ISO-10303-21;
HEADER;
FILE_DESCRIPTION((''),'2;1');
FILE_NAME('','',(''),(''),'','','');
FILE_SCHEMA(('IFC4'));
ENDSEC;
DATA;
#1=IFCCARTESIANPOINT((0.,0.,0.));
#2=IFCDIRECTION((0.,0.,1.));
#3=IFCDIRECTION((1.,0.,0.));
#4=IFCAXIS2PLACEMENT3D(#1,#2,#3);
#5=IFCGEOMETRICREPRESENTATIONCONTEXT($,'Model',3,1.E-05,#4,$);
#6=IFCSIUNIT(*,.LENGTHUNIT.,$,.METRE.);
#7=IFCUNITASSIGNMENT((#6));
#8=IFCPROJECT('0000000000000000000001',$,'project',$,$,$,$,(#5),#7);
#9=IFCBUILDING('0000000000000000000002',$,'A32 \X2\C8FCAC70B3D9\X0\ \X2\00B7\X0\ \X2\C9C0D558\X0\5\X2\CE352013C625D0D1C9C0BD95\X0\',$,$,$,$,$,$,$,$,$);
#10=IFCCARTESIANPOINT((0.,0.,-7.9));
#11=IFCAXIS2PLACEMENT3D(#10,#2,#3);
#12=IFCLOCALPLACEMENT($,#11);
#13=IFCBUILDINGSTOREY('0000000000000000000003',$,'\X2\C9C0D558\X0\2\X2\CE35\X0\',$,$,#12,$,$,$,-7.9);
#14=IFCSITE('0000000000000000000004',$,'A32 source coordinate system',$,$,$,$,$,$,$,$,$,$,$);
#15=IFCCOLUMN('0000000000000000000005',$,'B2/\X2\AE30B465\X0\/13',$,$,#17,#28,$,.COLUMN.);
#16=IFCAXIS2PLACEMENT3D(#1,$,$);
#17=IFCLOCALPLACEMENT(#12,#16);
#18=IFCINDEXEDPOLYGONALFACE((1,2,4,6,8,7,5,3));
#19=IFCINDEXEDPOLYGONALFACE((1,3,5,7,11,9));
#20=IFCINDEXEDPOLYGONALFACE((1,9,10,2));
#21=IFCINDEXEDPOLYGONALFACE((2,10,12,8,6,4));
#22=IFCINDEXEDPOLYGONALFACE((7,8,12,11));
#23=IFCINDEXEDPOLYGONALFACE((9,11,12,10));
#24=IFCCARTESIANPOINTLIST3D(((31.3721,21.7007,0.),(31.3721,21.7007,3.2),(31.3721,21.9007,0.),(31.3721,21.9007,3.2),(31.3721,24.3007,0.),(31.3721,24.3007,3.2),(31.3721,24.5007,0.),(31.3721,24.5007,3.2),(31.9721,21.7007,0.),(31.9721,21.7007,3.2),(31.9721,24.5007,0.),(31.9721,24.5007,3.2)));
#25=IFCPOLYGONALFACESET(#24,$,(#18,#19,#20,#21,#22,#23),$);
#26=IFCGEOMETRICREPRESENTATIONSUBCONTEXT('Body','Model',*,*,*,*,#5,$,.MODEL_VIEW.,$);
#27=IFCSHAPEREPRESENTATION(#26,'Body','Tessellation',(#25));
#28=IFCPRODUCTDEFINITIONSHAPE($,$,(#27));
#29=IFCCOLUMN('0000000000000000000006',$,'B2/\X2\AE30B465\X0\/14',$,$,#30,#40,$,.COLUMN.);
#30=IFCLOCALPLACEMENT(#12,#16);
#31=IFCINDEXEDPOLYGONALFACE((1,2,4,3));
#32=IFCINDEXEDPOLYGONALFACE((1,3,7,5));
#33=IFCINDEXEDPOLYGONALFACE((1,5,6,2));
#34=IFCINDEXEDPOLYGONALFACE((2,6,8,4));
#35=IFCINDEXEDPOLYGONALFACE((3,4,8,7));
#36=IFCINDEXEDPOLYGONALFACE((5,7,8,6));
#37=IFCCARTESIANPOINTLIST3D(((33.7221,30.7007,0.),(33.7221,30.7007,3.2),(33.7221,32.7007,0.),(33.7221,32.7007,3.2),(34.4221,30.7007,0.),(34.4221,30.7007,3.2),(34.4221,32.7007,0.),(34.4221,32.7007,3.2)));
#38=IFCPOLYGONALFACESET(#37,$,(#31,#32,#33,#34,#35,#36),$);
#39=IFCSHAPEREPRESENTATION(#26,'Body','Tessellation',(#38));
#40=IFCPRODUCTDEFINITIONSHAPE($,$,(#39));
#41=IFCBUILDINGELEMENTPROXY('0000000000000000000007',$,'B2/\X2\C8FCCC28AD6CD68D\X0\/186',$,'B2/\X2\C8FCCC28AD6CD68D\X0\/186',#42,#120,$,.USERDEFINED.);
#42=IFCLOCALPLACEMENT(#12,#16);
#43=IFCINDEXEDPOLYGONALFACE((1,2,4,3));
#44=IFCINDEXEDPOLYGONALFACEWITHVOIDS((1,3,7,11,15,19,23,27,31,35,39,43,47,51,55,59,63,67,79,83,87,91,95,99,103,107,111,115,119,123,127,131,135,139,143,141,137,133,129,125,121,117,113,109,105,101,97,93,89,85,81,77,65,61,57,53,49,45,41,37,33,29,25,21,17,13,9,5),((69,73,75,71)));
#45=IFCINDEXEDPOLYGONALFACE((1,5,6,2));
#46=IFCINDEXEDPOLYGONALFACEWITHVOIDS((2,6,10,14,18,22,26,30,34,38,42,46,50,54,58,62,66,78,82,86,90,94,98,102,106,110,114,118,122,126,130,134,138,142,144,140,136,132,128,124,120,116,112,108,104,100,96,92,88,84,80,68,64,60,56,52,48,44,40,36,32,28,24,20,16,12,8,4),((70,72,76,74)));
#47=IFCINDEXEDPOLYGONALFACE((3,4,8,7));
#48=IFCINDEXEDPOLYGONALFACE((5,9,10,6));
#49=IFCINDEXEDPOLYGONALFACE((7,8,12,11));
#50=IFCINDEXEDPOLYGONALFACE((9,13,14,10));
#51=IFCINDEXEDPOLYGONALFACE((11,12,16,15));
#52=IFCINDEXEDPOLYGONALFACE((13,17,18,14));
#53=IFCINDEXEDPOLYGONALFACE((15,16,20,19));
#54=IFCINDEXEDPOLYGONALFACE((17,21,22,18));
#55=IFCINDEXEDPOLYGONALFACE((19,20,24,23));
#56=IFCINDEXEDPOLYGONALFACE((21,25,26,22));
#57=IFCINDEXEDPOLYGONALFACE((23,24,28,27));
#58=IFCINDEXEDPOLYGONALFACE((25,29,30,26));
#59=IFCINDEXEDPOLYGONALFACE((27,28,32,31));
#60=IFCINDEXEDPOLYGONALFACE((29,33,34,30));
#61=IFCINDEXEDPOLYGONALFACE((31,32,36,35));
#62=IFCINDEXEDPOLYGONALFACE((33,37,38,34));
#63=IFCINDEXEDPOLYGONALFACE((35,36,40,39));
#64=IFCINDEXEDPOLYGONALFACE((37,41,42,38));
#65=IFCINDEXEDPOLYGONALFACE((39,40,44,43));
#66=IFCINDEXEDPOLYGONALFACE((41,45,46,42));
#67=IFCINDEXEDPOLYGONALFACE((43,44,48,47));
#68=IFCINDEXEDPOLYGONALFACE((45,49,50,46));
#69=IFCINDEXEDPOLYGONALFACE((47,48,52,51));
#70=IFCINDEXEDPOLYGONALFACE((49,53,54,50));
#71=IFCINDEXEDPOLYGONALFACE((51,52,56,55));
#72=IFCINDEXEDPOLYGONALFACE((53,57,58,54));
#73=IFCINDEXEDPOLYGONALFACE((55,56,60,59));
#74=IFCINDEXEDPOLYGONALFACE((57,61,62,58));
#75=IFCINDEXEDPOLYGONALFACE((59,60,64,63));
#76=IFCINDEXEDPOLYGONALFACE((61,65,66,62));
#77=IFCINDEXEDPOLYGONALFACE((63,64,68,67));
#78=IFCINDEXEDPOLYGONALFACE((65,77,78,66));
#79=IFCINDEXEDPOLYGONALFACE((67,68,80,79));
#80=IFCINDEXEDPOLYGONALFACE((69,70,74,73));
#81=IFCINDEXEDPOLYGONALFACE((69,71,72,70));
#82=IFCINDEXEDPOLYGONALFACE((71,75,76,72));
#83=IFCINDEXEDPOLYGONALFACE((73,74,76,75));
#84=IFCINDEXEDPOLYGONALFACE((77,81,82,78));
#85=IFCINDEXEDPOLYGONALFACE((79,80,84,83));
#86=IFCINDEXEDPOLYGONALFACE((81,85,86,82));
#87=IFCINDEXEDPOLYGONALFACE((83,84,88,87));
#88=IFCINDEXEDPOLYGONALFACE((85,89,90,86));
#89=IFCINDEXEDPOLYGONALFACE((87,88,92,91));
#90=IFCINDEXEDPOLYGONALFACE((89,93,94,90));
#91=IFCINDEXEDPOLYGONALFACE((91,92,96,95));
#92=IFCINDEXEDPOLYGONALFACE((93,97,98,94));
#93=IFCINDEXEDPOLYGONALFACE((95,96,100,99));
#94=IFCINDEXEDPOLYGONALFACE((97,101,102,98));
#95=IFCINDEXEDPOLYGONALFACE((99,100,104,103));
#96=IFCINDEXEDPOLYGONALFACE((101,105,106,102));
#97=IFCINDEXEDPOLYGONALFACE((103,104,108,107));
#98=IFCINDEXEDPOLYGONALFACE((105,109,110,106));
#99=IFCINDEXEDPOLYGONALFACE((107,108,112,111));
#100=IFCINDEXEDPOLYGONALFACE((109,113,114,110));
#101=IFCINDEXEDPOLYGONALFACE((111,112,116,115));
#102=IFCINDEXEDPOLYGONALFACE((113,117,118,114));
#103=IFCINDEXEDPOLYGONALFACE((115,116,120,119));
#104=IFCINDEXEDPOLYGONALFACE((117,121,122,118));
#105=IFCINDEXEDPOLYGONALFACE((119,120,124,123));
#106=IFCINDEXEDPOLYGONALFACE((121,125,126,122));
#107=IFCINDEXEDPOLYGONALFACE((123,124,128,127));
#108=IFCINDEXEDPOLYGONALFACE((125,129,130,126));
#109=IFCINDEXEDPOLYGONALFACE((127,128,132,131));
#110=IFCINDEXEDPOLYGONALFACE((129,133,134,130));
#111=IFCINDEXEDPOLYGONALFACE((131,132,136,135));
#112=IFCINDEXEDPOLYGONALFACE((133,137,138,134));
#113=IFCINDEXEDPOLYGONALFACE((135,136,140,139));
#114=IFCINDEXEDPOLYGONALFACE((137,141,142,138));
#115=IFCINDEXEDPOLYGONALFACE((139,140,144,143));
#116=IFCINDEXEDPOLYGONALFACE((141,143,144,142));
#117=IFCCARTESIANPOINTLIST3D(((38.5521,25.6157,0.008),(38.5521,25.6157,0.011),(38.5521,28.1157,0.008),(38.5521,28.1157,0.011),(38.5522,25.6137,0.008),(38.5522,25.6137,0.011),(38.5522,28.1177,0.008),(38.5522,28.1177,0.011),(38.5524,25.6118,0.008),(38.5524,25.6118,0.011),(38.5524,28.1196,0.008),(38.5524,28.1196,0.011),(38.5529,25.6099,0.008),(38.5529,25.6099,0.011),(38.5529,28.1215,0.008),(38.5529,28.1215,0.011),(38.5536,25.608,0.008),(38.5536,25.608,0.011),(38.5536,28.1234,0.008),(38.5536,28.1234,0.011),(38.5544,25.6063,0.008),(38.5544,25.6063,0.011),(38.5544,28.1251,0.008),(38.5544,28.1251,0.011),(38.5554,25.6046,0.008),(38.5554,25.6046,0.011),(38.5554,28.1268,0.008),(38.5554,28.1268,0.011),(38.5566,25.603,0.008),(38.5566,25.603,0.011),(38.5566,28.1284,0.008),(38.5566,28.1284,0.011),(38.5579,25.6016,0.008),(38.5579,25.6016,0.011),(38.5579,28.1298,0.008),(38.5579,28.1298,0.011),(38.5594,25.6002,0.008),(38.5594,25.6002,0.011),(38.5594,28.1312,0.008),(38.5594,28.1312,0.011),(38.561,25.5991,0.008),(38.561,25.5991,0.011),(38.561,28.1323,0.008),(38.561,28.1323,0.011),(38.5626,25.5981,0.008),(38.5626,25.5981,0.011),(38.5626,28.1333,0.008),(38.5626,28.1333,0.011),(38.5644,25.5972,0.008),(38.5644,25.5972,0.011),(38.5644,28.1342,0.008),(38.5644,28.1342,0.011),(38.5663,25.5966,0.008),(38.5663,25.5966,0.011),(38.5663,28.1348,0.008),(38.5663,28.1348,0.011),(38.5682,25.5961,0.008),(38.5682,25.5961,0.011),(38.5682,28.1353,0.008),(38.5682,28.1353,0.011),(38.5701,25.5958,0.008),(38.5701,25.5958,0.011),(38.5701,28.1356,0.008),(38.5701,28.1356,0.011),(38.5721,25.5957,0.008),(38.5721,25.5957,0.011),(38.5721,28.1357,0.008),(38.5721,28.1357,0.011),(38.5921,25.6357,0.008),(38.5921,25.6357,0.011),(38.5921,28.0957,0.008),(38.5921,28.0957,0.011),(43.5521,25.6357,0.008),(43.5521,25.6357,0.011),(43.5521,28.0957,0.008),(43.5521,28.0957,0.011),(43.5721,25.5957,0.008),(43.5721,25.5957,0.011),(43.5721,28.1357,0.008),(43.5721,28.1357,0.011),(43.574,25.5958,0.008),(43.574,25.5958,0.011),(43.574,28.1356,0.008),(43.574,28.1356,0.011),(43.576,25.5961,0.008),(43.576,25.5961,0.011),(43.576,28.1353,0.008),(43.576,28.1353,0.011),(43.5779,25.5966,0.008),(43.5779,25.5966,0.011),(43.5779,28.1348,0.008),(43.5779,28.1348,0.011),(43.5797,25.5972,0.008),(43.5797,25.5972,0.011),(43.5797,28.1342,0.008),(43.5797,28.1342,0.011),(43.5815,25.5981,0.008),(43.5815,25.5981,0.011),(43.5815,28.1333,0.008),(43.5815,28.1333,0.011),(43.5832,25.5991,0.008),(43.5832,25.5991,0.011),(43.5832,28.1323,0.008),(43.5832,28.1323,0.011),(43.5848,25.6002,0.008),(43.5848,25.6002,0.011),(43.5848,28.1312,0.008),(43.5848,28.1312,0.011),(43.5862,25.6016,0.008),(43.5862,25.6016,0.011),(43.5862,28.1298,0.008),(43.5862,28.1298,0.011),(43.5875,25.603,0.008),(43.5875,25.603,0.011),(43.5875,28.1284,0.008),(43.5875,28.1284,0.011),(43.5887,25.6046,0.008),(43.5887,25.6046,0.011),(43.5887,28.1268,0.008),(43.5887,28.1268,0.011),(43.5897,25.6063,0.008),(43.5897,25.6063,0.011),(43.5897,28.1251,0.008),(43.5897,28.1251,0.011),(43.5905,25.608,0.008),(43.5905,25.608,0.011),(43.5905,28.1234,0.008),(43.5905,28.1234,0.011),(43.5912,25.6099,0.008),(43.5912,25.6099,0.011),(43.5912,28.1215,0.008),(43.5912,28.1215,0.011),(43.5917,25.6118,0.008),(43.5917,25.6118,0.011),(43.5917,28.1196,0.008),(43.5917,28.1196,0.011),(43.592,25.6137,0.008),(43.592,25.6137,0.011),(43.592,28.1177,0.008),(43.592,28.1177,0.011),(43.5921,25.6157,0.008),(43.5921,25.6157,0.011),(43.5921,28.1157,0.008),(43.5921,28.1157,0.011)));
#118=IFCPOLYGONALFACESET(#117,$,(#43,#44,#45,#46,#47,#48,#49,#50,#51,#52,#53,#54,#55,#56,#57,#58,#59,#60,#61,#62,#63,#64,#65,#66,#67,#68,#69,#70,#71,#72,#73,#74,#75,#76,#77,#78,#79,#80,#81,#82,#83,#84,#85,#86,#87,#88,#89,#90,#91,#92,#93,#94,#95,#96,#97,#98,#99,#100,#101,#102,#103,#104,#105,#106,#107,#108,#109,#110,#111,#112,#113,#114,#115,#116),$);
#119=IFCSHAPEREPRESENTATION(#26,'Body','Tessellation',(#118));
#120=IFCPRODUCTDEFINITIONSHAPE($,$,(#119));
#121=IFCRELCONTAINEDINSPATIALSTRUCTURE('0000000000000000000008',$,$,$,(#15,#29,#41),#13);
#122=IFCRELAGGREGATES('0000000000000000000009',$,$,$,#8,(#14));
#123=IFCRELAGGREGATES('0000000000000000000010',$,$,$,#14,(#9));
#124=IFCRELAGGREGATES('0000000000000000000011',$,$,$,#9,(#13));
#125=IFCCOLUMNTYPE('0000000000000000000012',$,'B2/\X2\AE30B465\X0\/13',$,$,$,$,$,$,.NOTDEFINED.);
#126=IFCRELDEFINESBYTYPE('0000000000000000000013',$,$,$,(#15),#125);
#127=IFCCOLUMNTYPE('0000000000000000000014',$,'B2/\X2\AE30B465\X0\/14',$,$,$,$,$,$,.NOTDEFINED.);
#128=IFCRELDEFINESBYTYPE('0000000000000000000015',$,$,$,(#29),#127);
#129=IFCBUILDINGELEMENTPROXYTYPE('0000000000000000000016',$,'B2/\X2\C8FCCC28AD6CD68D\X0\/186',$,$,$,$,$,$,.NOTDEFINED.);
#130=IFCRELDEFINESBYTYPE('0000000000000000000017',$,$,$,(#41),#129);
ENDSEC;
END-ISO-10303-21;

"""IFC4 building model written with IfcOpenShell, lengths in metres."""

from ifc_helpers import new_model, si_unit, frame, origin, origin_with_axes, place, context, subcontext, project, spatial, polyline, outline, extrude, source, transform, mapped, type_object, type_shapes, element, save


model = new_model("IFC4")

# Units and contexts
model_context = context("Model", 3, precision=1e-05, world=origin_with_axes())
body_context = subcontext(model_context, "Body", "Model", "MODEL_VIEW")
ifc_project = project(units=[si_unit("LENGTHUNIT", "METRE")], contexts=[model_context])

# Site, building, storey
site = spatial("IfcSite", under=ifc_project, Name="A32 source coordinate system")
building = spatial("IfcBuilding", under=site, Name="A32 주거동 · 지하5층–옥탑지붕")
storey_placement = place(None, frame((0.0, 0.0, -7.9), z_axis=(0.0, 0.0, 1.0), x_axis=(1.0, 0.0, 0.0)))
storey = spatial("IfcBuildingStorey", under=building, at=storey_placement, Name="지하2층", Elevation=-7.9)

# Columns
column_type_1 = type_object("IfcColumnType", Name="B2/기둥/13", PredefinedType="NOTDEFINED")
shared_shape_1 = source(origin(), body_context, "Body", "SweptSolid", [
    extrude(outline(polyline([(31.3721, 24.5007), (31.9721, 24.5007), (31.9721, 21.7007), (31.3721, 21.7007), (31.3721, 21.9007), (31.3721, 24.3007), (31.3721, 24.5007)])), origin(), (0.0, 0.0, 1.0), 3.2),
])
type_shapes(column_type_1, [shared_shape_1])
column_1_placement = place(storey_placement, origin_with_axes())
element("IfcColumn", 1, at=column_1_placement, inside=storey, type_object=column_type_1, Name="B2/기둥/13", PredefinedType="COLUMN", context=body_context, shape_type="MappedRepresentation", body=[
    mapped(shared_shape_1, transform((0.0, 0.0, 0.0), scale=1.0)),
])
column_type_2 = type_object("IfcColumnType", Name="B2/기둥/14", PredefinedType="NOTDEFINED")
shared_shape_2 = source(origin(), body_context, "Body", "SweptSolid", [
    extrude(outline(polyline([(34.4221, 32.7007), (34.4221, 30.7007), (33.7221, 30.7007), (33.7221, 32.7007), (34.4221, 32.7007)])), origin(), (0.0, 0.0, 1.0), 3.2),
])
type_shapes(column_type_2, [shared_shape_2])
column_2_placement = place(storey_placement, origin_with_axes())
element("IfcColumn", 2, at=column_2_placement, inside=storey, type_object=column_type_2, Name="B2/기둥/14", PredefinedType="COLUMN", context=body_context, shape_type="MappedRepresentation", body=[
    mapped(shared_shape_2, transform((0.0, 0.0, 0.0), scale=1.0)),
])

# Building element proxy
building_element_proxy_type_1 = type_object("IfcBuildingElementProxyType", Name="B2/주차구획/186", PredefinedType="NOTDEFINED")
shared_shape_3 = source(origin(), body_context, "Body", "SweptSolid", [
    extrude(outline(polyline([(43.5721, 28.1357), (43.574, 28.1356), (43.576, 28.1353), (43.5779, 28.1348), (43.5797, 28.1342), (43.5815, 28.1333), (43.5832, 28.1323), (43.5848, 28.1312), (43.5862, 28.1298), (43.5875, 28.1284), (43.5887, 28.1268), (43.5897, 28.1251), (43.5905, 28.1234), (43.5912, 28.1215), (43.5917, 28.1196), (43.592, 28.1177), (43.5921, 28.1157), (43.5921, 25.6157), (43.592, 25.6137), (43.5917, 25.6118), (43.5912, 25.6099), (43.5905, 25.608), (43.5897, 25.6063), (43.5887, 25.6046), (43.5875, 25.603), (43.5862, 25.6016), (43.5848, 25.6002), (43.5832, 25.5991), (43.5815, 25.5981), (43.5797, 25.5972), (43.5779, 25.5966), (43.576, 25.5961), (43.574, 25.5958), (43.5721, 25.5957), (38.5721, 25.5957), (38.5701, 25.5958), (38.5682, 25.5961), (38.5663, 25.5966), (38.5644, 25.5972), (38.5626, 25.5981), (38.561, 25.5991), (38.5594, 25.6002), (38.5579, 25.6016), (38.5566, 25.603), (38.5554, 25.6046), (38.5544, 25.6063), (38.5536, 25.608), (38.5529, 25.6099), (38.5524, 25.6118), (38.5522, 25.6137), (38.5521, 25.6157), (38.5521, 28.1157), (38.5522, 28.1177), (38.5524, 28.1196), (38.5529, 28.1215), (38.5536, 28.1234), (38.5544, 28.1251), (38.5554, 28.1268), (38.5566, 28.1284), (38.5579, 28.1298), (38.5594, 28.1312), (38.561, 28.1323), (38.5626, 28.1333), (38.5644, 28.1342), (38.5663, 28.1348), (38.5682, 28.1353), (38.5701, 28.1356), (38.5721, 28.1357), (43.5721, 28.1357)]), holes=[polyline([(43.5521, 28.0957), (38.5921, 28.0957), (38.5921, 25.6357), (43.5521, 25.6357), (43.5521, 28.0957)])]), frame((0.0, 0.0, 0.008)), (0.0, 0.0, 1.0), 0.003),
])
type_shapes(building_element_proxy_type_1, [shared_shape_3])
proxy_1_placement = place(storey_placement, origin_with_axes())
element("IfcBuildingElementProxy", 3, at=proxy_1_placement, inside=storey, type_object=building_element_proxy_type_1, Name="B2/주차구획/186", ObjectType="B2/주차구획/186", PredefinedType="USERDEFINED", context=body_context, shape_type="MappedRepresentation", body=[
    mapped(shared_shape_3, transform((0.0, 0.0, 0.0), scale=1.0)),
])

save(model, "model.ifc")
